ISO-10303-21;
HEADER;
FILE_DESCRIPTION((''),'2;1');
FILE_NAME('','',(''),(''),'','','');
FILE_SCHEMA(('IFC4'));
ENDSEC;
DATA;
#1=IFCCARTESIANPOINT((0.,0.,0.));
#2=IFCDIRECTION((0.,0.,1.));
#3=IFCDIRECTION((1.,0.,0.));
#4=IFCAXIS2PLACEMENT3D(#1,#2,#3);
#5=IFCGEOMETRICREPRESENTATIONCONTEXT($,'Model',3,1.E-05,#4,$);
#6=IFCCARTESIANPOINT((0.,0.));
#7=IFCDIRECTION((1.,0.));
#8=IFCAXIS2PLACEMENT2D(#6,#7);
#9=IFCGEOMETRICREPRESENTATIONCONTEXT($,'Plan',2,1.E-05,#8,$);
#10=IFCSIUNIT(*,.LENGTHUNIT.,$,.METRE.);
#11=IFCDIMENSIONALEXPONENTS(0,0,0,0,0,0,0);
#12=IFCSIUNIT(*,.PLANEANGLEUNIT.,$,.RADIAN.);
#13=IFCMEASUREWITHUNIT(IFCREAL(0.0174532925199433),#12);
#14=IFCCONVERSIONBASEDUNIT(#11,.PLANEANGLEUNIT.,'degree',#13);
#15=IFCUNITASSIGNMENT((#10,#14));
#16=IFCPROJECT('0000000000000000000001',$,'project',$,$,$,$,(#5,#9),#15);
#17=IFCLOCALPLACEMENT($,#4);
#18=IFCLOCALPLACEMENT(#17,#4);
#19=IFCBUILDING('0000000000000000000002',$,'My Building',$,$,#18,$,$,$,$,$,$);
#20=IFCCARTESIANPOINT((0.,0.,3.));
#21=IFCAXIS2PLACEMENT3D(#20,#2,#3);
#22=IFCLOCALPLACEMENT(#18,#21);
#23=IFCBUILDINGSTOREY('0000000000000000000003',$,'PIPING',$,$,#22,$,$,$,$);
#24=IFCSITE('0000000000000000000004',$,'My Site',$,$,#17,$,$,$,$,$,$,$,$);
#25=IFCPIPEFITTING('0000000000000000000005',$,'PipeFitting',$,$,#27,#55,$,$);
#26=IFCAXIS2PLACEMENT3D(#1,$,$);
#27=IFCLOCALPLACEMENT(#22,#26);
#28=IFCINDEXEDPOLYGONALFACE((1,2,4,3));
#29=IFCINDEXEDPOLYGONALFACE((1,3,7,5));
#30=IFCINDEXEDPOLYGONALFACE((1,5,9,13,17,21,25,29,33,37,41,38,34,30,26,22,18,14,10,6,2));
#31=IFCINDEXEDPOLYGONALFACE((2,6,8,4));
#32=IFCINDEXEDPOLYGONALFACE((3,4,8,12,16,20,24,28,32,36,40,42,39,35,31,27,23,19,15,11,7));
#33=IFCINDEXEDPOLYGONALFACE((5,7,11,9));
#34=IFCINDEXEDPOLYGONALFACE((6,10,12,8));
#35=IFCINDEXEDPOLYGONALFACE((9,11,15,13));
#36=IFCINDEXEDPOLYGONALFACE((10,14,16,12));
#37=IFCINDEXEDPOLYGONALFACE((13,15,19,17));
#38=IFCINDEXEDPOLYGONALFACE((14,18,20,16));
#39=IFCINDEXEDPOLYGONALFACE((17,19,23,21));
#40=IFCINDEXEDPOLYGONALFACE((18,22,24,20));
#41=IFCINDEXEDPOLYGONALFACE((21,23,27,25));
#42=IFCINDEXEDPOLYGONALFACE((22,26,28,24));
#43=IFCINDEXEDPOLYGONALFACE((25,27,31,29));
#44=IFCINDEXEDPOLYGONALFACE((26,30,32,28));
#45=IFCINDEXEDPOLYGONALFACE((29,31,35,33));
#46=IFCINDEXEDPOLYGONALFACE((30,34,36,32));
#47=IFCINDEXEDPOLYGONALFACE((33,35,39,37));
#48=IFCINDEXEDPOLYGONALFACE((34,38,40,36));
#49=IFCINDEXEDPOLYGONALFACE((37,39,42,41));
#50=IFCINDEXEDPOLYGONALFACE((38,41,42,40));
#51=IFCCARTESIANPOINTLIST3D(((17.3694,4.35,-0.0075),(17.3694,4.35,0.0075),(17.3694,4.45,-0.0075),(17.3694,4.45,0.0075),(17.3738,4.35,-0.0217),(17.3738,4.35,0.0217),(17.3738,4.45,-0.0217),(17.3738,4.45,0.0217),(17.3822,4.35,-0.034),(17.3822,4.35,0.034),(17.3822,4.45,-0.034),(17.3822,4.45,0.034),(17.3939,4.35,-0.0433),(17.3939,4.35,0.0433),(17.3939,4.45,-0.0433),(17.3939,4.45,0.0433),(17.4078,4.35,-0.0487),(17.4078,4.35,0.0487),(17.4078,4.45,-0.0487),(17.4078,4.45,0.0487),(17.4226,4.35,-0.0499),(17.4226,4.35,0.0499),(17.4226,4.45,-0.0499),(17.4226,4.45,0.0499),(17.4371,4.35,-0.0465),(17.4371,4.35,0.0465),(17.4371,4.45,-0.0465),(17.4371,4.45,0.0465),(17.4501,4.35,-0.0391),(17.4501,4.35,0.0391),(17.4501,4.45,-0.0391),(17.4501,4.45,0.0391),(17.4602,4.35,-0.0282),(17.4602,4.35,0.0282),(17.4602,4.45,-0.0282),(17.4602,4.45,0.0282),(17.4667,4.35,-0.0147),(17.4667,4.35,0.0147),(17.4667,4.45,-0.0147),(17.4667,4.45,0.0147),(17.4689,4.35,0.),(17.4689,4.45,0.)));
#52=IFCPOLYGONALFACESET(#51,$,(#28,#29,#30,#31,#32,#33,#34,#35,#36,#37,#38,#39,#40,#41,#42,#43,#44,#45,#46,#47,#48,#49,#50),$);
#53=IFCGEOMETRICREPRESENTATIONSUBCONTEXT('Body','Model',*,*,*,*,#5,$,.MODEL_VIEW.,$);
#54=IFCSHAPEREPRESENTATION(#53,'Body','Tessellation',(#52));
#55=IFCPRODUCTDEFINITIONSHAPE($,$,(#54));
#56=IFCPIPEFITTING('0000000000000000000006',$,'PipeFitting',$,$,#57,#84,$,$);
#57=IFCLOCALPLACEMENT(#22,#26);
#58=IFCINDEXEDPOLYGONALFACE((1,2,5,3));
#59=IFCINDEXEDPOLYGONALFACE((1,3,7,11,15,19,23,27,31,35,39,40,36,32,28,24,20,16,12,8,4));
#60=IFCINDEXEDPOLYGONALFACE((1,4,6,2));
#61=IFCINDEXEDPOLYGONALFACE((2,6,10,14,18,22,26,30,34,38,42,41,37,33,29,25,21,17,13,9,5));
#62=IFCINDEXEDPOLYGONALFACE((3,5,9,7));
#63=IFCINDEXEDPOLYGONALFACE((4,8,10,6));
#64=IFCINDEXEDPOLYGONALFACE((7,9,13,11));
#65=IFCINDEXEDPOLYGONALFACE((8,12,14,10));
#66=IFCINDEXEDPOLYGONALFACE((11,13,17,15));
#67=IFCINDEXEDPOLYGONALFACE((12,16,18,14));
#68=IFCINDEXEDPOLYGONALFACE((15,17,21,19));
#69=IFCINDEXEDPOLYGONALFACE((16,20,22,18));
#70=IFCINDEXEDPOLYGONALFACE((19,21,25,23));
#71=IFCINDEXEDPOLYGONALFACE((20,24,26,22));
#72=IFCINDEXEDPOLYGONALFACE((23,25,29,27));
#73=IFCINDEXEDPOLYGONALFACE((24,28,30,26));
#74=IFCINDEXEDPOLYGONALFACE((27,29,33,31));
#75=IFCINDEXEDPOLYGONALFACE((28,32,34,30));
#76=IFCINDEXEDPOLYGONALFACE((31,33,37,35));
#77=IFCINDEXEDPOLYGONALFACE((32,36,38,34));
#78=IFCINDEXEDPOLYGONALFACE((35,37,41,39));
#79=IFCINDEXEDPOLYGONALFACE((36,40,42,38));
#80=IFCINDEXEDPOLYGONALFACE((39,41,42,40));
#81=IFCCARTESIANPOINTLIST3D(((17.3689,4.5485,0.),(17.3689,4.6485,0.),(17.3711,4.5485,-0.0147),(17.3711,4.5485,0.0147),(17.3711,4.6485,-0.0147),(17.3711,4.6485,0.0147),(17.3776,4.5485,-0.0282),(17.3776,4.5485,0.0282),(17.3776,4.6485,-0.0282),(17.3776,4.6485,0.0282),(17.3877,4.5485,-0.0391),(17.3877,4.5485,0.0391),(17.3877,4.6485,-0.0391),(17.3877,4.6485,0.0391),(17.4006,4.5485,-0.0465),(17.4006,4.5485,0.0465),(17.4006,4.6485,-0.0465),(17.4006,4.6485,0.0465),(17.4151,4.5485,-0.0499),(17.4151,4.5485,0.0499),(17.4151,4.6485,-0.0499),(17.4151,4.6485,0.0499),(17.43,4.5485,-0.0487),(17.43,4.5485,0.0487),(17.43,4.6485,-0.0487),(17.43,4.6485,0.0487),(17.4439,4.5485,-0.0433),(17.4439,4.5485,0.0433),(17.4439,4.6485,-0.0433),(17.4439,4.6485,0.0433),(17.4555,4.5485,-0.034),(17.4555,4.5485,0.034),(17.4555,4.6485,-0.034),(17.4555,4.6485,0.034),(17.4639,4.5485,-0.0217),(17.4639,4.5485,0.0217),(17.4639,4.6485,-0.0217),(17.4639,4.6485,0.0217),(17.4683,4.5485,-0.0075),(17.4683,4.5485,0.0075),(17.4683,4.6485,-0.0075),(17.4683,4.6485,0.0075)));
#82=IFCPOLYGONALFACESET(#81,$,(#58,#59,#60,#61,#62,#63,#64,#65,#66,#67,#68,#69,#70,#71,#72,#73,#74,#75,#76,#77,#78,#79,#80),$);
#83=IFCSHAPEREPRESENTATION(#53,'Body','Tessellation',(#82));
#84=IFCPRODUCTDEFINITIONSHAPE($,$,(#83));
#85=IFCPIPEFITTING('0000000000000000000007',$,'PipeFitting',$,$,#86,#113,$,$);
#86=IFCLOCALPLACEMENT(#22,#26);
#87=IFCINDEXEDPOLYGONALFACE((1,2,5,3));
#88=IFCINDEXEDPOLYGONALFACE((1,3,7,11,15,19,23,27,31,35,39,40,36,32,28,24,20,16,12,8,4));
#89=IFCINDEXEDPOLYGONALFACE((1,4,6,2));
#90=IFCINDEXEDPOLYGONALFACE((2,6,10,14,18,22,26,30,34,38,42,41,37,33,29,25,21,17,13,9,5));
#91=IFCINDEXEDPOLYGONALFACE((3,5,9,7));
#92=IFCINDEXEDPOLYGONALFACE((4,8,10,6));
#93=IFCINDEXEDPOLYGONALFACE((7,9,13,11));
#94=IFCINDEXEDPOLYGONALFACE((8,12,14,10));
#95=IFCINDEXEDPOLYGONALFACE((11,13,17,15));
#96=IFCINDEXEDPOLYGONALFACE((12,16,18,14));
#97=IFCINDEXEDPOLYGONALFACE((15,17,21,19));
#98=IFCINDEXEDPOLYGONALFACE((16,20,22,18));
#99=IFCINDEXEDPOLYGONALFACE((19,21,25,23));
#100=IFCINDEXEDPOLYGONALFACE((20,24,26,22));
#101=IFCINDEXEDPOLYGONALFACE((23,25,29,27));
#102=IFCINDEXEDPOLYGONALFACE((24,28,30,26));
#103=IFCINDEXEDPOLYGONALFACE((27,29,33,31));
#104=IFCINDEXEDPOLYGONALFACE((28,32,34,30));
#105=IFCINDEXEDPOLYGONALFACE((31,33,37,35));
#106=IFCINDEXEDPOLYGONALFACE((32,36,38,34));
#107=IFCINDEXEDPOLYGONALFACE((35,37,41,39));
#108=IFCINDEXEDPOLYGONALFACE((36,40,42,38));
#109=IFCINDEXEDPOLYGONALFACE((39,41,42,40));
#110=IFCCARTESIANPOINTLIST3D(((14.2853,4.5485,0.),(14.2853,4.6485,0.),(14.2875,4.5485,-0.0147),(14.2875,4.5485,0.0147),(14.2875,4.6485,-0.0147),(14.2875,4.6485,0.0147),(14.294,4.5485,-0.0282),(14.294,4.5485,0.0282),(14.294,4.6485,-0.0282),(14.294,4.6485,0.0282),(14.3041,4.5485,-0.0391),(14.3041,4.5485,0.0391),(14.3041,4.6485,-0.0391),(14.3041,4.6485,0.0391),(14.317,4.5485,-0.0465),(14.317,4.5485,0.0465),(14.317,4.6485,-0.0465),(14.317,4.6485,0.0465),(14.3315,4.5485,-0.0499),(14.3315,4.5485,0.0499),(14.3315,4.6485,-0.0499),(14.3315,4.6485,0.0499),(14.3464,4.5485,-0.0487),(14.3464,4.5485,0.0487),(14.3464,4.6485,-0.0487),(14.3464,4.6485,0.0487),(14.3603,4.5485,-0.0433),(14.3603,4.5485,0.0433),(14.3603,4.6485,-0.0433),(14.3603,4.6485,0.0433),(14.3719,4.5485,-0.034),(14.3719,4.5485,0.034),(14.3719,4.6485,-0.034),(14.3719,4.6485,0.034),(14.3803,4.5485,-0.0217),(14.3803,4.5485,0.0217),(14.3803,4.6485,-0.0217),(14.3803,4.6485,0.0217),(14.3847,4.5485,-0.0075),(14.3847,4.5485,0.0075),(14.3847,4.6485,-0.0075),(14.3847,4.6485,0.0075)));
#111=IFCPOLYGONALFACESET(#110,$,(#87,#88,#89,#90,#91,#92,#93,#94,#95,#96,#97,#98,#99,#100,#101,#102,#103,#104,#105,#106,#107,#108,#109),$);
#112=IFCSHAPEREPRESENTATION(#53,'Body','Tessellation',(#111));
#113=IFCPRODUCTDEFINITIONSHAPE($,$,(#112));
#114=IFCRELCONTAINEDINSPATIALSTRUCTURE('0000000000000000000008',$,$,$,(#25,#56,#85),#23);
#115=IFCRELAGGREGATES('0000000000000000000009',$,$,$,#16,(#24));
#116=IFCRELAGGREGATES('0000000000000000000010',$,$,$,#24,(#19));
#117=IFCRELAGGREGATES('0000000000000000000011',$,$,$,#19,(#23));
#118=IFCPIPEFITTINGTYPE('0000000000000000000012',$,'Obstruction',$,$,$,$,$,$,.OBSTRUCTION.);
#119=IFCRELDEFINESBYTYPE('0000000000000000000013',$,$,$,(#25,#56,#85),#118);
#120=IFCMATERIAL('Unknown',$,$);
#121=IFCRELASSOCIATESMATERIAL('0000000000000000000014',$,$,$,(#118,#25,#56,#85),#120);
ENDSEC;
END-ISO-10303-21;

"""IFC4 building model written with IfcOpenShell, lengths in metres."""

from ifc_helpers import new_model, entity, si_unit, converted_unit, frame, origin_with_axes, origin_2d_with_axis, place, context, subcontext, project, spatial, circle, extrude, material, material_profile, profile_set, profile_usage, type_object, element, save


model = new_model("IFC4")

# Units and contexts
model_context = context("Model", 3, precision=1e-05, world=origin_with_axes())
plan_context = context("Plan", 2, precision=1e-05, world=origin_2d_with_axis())
body_context = subcontext(model_context, "Body", "Model", "MODEL_VIEW")
ifc_project = project(units=[si_unit("LENGTHUNIT", "METRE"), converted_unit("PLANEANGLEUNIT", "degree", entity("IfcReal", 0.0174532925199433), si_unit("PLANEANGLEUNIT", "RADIAN"), dimensions=[0, 0, 0, 0, 0, 0, 0])], contexts=[model_context, plan_context])

# Site, building, storey
site_placement = place(None, origin_with_axes())
site = spatial("IfcSite", under=ifc_project, at=site_placement, Name="My Site")
building_placement = place(site_placement, origin_with_axes())
building = spatial("IfcBuilding", under=site, at=building_placement, Name="My Building")
storey_placement = place(building_placement, frame((0.0, 0.0, 3.0), z_axis=(0.0, 0.0, 1.0), x_axis=(1.0, 0.0, 0.0)))
storey = spatial("IfcBuildingStorey", under=building, at=storey_placement, Name="PIPING")

# Shared definitions
ifc_material = material(Name="Unknown")

# Pipe fittings
ifc_material_profile_1 = material_profile(ifc_material, circle(Radius=0.05))
ifc_profile_set_1 = profile_set([ifc_material_profile_1])
pipe_fitting_type_1 = type_object("IfcPipeFittingType", Name="Obstruction", PredefinedType="OBSTRUCTION", material=ifc_profile_set_1)
ifc_profile_usage_1 = profile_usage(ifc_profile_set_1, cardinal=5)
pipe_fitting_1_placement = place(storey_placement, frame((17.4189, 4.45, 0.0), z_axis=(0.0, -1.0, 0.0), x_axis=(1.0, 0.0, 0.0)))
element("IfcPipeFitting", 1, at=pipe_fitting_1_placement, inside=storey, type_object=pipe_fitting_type_1, material=ifc_profile_usage_1, Name="PipeFitting", context=body_context, shape_type="SweptSolid", body=[
    extrude(circle(Radius=0.05), origin_with_axes(), (0.0, 0.0, 1.0), 0.1),
])
ifc_profile_usage_2 = profile_usage(ifc_profile_set_1, cardinal=5)
pipe_fitting_2_placement = place(storey_placement, frame((17.4189, 4.5485, 0.0), z_axis=(0.0, 1.0, 0.0), x_axis=(-1.0, 0.0, 0.0)))
element("IfcPipeFitting", 2, at=pipe_fitting_2_placement, inside=storey, type_object=pipe_fitting_type_1, material=ifc_profile_usage_2, Name="PipeFitting", context=body_context, shape_type="SweptSolid", body=[
    extrude(circle(Radius=0.05), origin_with_axes(), (0.0, 0.0, 1.0), 0.1),
])
ifc_profile_usage_3 = profile_usage(ifc_profile_set_1, cardinal=5)
pipe_fitting_3_placement = place(storey_placement, frame((14.3353, 4.5485, 0.0), z_axis=(0.0, 1.0, 0.0), x_axis=(-1.0, 0.0, 0.0)))
element("IfcPipeFitting", 3, at=pipe_fitting_3_placement, inside=storey, type_object=pipe_fitting_type_1, material=ifc_profile_usage_3, Name="PipeFitting", context=body_context, shape_type="SweptSolid", body=[
    extrude(circle(Radius=0.05), origin_with_axes(), (0.0, 0.0, 1.0), 0.1),
])

save(model, "model.ifc")
